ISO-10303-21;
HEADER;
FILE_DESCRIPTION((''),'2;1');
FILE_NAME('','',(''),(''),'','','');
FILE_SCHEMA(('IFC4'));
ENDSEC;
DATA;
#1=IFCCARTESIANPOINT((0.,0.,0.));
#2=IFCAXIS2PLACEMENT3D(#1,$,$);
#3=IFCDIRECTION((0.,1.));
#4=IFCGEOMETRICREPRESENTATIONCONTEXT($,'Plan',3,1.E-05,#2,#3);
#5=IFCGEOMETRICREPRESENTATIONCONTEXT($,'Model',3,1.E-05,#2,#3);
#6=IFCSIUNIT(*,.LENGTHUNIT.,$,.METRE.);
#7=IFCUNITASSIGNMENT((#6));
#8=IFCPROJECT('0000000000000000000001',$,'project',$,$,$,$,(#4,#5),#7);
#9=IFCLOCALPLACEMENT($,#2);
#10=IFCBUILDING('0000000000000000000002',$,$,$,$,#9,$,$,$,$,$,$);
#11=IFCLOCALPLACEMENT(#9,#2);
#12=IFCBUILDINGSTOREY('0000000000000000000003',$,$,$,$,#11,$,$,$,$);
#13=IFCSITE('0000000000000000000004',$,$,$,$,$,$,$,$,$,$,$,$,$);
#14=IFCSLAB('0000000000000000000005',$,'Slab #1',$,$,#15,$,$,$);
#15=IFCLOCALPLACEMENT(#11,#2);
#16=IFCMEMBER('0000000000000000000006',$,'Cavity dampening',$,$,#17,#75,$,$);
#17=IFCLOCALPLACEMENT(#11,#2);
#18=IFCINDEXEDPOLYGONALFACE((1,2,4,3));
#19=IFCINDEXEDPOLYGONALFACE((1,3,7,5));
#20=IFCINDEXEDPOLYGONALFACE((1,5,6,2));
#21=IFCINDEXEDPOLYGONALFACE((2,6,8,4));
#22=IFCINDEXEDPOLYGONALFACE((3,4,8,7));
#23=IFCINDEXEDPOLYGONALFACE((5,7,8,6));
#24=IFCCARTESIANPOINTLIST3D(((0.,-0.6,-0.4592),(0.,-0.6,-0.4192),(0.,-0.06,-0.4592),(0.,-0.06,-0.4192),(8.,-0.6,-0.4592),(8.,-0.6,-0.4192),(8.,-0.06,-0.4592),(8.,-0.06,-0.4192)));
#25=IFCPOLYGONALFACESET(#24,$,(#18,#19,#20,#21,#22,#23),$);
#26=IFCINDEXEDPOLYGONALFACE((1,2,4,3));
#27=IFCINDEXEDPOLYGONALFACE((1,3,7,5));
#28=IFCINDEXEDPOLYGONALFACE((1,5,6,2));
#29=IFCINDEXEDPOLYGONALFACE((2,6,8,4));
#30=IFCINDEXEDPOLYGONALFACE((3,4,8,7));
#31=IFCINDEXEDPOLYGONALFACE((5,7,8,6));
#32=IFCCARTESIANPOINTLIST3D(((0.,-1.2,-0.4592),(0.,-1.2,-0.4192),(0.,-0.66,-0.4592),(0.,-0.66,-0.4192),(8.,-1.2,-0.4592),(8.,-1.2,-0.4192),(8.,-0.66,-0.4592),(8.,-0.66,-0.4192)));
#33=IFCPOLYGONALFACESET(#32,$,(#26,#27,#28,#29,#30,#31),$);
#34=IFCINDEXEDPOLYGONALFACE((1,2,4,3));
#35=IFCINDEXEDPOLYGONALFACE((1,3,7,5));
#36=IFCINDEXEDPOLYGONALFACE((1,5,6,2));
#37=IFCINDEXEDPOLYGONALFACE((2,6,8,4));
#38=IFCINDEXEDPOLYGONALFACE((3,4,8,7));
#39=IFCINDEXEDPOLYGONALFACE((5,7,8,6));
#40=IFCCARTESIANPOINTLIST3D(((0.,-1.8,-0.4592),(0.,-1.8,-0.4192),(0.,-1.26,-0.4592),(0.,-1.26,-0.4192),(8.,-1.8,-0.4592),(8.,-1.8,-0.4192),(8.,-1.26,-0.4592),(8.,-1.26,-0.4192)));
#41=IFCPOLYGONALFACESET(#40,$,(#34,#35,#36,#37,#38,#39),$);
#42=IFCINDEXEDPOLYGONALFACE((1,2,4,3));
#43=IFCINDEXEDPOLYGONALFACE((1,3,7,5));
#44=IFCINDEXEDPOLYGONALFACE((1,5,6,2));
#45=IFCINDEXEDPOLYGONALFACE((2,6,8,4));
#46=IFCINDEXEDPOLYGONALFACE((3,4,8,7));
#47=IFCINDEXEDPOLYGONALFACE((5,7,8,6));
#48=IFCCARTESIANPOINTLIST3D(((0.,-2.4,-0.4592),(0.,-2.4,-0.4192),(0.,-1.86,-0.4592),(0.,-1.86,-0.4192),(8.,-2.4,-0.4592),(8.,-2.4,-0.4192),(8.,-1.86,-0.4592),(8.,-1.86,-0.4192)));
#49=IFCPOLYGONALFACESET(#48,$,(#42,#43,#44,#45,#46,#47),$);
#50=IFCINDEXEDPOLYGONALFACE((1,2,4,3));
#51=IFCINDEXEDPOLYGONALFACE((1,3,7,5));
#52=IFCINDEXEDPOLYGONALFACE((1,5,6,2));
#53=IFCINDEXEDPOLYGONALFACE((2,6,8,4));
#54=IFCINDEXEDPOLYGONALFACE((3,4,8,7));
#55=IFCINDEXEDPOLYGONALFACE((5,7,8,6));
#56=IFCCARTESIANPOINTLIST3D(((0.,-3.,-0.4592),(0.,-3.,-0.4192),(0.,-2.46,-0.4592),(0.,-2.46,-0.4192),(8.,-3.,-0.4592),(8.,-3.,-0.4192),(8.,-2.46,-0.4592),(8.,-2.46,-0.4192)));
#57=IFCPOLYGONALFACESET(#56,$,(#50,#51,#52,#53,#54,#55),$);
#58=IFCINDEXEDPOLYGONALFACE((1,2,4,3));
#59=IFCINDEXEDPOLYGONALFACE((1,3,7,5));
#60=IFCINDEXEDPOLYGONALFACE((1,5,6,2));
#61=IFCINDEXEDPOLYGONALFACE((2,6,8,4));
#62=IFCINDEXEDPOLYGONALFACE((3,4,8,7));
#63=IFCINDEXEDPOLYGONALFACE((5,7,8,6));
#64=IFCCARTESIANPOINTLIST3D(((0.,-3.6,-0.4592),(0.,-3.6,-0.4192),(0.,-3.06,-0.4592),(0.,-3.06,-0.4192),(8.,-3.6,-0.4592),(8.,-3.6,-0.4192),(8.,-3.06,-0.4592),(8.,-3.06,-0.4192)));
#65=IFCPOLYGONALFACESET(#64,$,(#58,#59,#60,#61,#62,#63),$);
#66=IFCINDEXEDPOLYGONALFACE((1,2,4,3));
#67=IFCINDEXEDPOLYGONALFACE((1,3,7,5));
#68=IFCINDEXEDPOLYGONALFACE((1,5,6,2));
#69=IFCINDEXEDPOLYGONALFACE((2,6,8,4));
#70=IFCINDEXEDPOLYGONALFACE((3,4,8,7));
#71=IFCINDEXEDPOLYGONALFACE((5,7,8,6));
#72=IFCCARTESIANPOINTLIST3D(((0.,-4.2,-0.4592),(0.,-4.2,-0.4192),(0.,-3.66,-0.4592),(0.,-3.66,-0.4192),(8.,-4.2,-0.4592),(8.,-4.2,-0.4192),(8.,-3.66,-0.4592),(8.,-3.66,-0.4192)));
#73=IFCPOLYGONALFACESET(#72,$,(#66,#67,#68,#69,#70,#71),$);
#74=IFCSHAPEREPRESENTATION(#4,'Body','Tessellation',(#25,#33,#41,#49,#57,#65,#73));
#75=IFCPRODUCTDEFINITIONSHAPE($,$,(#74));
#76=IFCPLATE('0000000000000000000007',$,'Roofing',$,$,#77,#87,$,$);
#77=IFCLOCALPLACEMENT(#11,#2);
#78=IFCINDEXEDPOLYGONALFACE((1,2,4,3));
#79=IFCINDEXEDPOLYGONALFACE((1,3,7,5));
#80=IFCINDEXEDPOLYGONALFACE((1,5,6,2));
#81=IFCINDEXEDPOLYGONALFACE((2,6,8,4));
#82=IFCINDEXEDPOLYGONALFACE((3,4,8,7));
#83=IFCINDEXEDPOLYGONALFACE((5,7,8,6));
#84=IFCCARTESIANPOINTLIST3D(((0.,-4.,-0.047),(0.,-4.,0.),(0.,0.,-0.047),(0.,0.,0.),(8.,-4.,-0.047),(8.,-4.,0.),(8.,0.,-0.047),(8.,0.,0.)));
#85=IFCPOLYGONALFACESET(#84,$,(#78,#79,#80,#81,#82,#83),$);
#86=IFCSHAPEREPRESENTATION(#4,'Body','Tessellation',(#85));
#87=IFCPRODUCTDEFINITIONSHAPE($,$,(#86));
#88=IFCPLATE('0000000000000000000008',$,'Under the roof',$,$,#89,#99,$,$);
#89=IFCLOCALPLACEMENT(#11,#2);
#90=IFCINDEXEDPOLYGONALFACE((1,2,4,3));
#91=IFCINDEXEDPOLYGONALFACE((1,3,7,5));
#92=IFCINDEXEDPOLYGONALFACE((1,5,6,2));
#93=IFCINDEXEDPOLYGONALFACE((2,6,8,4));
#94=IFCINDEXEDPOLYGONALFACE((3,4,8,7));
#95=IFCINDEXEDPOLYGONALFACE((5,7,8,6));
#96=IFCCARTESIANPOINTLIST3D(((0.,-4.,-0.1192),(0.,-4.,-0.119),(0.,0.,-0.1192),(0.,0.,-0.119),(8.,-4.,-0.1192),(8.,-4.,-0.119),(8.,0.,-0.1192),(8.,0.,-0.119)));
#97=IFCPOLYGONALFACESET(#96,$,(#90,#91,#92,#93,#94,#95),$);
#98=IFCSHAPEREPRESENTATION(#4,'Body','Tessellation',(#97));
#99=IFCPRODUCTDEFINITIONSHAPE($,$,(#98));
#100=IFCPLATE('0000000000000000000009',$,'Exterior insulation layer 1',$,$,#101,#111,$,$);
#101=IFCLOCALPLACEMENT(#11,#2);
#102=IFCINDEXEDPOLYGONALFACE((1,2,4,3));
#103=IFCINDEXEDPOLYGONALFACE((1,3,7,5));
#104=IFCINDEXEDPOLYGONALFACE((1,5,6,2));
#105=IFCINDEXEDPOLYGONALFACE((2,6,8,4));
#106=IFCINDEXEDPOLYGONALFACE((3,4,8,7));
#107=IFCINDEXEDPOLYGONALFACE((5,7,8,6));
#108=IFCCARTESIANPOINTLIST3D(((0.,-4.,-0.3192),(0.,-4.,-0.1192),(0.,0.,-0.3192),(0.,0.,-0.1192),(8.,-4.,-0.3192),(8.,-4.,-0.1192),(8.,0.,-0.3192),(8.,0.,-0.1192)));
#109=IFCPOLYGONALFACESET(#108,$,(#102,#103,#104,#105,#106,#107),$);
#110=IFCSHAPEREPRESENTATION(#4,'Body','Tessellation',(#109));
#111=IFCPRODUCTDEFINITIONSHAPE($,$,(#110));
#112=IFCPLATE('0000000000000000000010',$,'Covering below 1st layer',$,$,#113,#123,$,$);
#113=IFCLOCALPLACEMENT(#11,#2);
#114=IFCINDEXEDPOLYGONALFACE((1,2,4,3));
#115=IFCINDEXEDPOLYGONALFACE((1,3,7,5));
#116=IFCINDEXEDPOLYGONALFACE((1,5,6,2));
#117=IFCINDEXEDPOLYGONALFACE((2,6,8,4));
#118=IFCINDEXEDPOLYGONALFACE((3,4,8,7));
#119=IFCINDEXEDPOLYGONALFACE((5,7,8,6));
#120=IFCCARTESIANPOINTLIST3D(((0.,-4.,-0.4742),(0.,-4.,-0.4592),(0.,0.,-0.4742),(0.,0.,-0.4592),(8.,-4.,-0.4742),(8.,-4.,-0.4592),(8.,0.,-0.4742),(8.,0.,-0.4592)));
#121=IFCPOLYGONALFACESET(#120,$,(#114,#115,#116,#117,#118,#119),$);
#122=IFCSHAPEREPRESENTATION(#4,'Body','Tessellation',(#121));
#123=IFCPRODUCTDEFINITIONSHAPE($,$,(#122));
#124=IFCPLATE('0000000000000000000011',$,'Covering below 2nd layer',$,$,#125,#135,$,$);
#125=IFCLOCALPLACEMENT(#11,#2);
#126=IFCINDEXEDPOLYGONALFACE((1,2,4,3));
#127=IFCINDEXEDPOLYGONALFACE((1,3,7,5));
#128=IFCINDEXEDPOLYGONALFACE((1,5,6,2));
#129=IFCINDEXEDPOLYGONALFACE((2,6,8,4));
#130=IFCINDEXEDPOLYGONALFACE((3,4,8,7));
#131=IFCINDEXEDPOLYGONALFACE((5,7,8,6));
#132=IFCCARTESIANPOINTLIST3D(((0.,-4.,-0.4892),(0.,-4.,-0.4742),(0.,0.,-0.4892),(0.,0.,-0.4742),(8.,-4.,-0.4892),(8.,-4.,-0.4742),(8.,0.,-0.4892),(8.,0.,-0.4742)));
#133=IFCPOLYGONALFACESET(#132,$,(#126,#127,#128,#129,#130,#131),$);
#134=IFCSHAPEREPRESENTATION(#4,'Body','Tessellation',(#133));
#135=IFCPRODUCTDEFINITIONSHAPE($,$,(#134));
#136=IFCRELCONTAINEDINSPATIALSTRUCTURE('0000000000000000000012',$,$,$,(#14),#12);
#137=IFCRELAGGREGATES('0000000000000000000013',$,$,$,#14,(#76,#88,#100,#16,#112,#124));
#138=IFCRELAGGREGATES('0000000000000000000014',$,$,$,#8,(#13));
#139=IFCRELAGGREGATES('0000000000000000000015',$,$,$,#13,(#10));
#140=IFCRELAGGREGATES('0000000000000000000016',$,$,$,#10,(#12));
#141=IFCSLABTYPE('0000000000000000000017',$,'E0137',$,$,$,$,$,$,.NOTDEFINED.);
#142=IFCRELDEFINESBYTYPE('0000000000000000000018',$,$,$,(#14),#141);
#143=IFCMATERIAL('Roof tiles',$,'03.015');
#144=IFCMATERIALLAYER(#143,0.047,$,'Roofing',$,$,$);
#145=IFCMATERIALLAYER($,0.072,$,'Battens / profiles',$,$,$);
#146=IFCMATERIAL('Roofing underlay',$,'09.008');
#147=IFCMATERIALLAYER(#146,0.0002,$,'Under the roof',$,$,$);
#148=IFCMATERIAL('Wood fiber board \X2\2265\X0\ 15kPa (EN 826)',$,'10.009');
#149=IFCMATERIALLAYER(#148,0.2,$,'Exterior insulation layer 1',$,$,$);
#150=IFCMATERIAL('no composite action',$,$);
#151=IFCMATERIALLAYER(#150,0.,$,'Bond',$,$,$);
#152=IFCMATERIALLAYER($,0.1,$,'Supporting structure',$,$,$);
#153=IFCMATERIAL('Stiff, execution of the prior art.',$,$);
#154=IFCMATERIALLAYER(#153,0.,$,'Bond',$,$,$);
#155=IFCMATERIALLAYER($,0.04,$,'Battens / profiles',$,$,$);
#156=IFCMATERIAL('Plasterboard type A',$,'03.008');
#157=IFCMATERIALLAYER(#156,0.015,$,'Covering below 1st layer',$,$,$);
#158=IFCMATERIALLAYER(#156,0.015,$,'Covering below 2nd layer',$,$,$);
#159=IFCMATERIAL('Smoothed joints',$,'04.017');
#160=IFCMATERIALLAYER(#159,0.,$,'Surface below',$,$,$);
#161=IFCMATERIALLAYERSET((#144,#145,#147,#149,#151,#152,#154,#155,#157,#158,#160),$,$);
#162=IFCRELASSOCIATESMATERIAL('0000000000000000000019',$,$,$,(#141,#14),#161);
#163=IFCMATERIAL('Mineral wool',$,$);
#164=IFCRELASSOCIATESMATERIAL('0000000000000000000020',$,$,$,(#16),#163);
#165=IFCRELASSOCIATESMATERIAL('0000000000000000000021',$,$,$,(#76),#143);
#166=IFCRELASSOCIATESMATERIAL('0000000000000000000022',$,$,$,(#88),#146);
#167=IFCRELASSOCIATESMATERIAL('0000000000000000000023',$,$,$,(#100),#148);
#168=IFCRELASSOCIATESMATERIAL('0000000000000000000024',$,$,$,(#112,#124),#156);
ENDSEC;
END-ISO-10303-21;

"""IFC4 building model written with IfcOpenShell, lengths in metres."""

from ifc_helpers import new_model, si_unit, direction, frame, frame_2d, origin, origin_with_axes, place, context, project, spatial, rectangle, extrude, material, layer, layer_set, type_object, element, aggregate, save


model = new_model("IFC4")

# Units and contexts
plan_context = context("Plan", 3, precision=1e-05, world=origin(), true_north=direction((0.0, 1.0)))
model_context = context("Model", 3, precision=1e-05, world=origin(), true_north=direction((0.0, 1.0)))
ifc_project = project(units=[si_unit("LENGTHUNIT", "METRE")], contexts=[plan_context, model_context])

# Site, building, storey
site = spatial("IfcSite", under=ifc_project)
building_placement = place(None, origin())
building = spatial("IfcBuilding", under=site, at=building_placement)
storey_placement = place(building_placement, origin())
storey = spatial("IfcBuildingStorey", under=building, at=storey_placement)

# Slab, member, plates
ifc_material_1 = material(Name="Roof tiles", Category="03.015")
ifc_layer_1 = layer(ifc_material_1, 0.047, Name="Roofing")
ifc_layer_2 = layer(None, 0.072, Name="Battens / profiles")
ifc_material_2 = material(Name="Roofing underlay", Category="09.008")
ifc_layer_3 = layer(ifc_material_2, 0.0002, Name="Under the roof")
ifc_material_3 = material(Name="Wood fiber board ≥ 15kPa (EN 826)", Category="10.009")
ifc_layer_4 = layer(ifc_material_3, 0.2, Name="Exterior insulation layer 1")
ifc_material_4 = material(Name="no composite action")
ifc_layer_5 = layer(ifc_material_4, 0.0, Name="Bond")
ifc_layer_6 = layer(None, 0.1, Name="Supporting structure")
ifc_material_5 = material(Name="Stiff, execution of the prior art.")
ifc_layer_7 = layer(ifc_material_5, 0.0, Name="Bond")
ifc_layer_8 = layer(None, 0.04, Name="Battens / profiles")
ifc_material_6 = material(Name="Plasterboard type A", Category="03.008")
ifc_layer_9 = layer(ifc_material_6, 0.015, Name="Covering below 1st layer")
ifc_layer_10 = layer(ifc_material_6, 0.015, Name="Covering below 2nd layer")
ifc_material_7 = material(Name="Smoothed joints", Category="04.017")
ifc_layer_11 = layer(ifc_material_7, 0.0, Name="Surface below")
ifc_layer_set = layer_set([ifc_layer_1, ifc_layer_2, ifc_layer_3, ifc_layer_4, ifc_layer_5, ifc_layer_6, ifc_layer_7, ifc_layer_8, ifc_layer_9, ifc_layer_10, ifc_layer_11])
slab_type = type_object("IfcSlabType", Name="E0137", PredefinedType="NOTDEFINED", material=ifc_layer_set)
slab_placement = place(None, frame((0.0, 0.0, 0.0), z_axis=(0.0, 0.0, -1.0), x_axis=(1.0, 0.0, 0.0)))
slab = element("IfcSlab", 1, at=slab_placement, inside=storey, type_object=slab_type, material=ifc_layer_set, Name="Slab #1")
ifc_material_8 = material(Name="Mineral wool")
member_1_placement = place(slab_placement, origin())
member_1 = element("IfcMember", 2, at=member_1_placement, material=ifc_material_8, Name="Cavity dampening", context=plan_context, shape_type="SweptSolid", body=[
    extrude(rectangle(XDim=0.54, YDim=0.04, at=frame_2d((0.27, 0.02), x_axis=(1.0, 0.0))), frame((0.0, 0.06, 0.4192), z_axis=(1.0, 0.0, 0.0), x_axis=(0.0, 1.0, 0.0)), (0.0, 0.0, 1.0), 8.0),
    extrude(rectangle(XDim=0.54, YDim=0.04, at=frame_2d((0.27, 0.02), x_axis=(1.0, 0.0))), frame((0.0, 0.66, 0.4192), z_axis=(1.0, 0.0, 0.0), x_axis=(0.0, 1.0, 0.0)), (0.0, 0.0, 1.0), 8.0),
    extrude(rectangle(XDim=0.54, YDim=0.04, at=frame_2d((0.27, 0.02), x_axis=(1.0, 0.0))), frame((0.0, 1.26, 0.4192), z_axis=(1.0, 0.0, 0.0), x_axis=(0.0, 1.0, 0.0)), (0.0, 0.0, 1.0), 8.0),
    extrude(rectangle(XDim=0.54, YDim=0.04, at=frame_2d((0.27, 0.02), x_axis=(1.0, 0.0))), frame((0.0, 1.86, 0.4192), z_axis=(1.0, 0.0, 0.0), x_axis=(0.0, 1.0, 0.0)), (0.0, 0.0, 1.0), 8.0),
    extrude(rectangle(XDim=0.54, YDim=0.04, at=frame_2d((0.27, 0.02), x_axis=(1.0, 0.0))), frame((0.0, 2.46, 0.4192), z_axis=(1.0, 0.0, 0.0), x_axis=(0.0, 1.0, 0.0)), (0.0, 0.0, 1.0), 8.0),
    extrude(rectangle(XDim=0.54, YDim=0.04, at=frame_2d((0.27, 0.02), x_axis=(1.0, 0.0))), frame((0.0, 3.06, 0.4192), z_axis=(1.0, 0.0, 0.0), x_axis=(0.0, 1.0, 0.0)), (0.0, 0.0, 1.0), 8.0),
    extrude(rectangle(XDim=0.54, YDim=0.04, at=frame_2d((0.27, 0.02), x_axis=(1.0, 0.0))), frame((0.0, 3.66, 0.4192), z_axis=(1.0, 0.0, 0.0), x_axis=(0.0, 1.0, 0.0)), (0.0, 0.0, 1.0), 8.0),
])
plate_1_placement = place(slab_placement, origin())
plate_1 = element("IfcPlate", 3, at=plate_1_placement, material=ifc_material_1, Name="Roofing", context=plan_context, shape_type="SweptSolid", body=[
    extrude(rectangle(XDim=8.0, YDim=4.0, at=frame_2d((4.0, 2.0), x_axis=(1.0, 0.0))), origin_with_axes(), (0.0, 0.0, 1.0), 0.047),
])
plate_2_placement = place(slab_placement, origin())
plate_2 = element("IfcPlate", 4, at=plate_2_placement, material=ifc_material_2, Name="Under the roof", context=plan_context, shape_type="SweptSolid", body=[
    extrude(rectangle(XDim=8.0, YDim=4.0, at=frame_2d((4.0, 2.0), x_axis=(1.0, 0.0))), frame((0.0, 0.0, 0.119), z_axis=(0.0, 0.0, 1.0), x_axis=(1.0, 0.0, 0.0)), (0.0, 0.0, 1.0), 0.0002),
])
plate_3_placement = place(slab_placement, origin())
plate_3 = element("IfcPlate", 5, at=plate_3_placement, material=ifc_material_3, Name="Exterior insulation layer 1", context=plan_context, shape_type="SweptSolid", body=[
    extrude(rectangle(XDim=8.0, YDim=4.0, at=frame_2d((4.0, 2.0), x_axis=(1.0, 0.0))), frame((0.0, 0.0, 0.1192), z_axis=(0.0, 0.0, 1.0), x_axis=(1.0, 0.0, 0.0)), (0.0, 0.0, 1.0), 0.2),
])
plate_4_placement = place(slab_placement, origin())
plate_4 = element("IfcPlate", 6, at=plate_4_placement, material=ifc_material_6, Name="Covering below 1st layer", context=plan_context, shape_type="SweptSolid", body=[
    extrude(rectangle(XDim=8.0, YDim=4.0, at=frame_2d((4.0, 2.0), x_axis=(1.0, 0.0))), frame((0.0, 0.0, 0.4592), z_axis=(0.0, 0.0, 1.0), x_axis=(1.0, 0.0, 0.0)), (0.0, 0.0, 1.0), 0.015),
])
plate_5_placement = place(slab_placement, origin())
plate_5 = element("IfcPlate", 7, at=plate_5_placement, material=ifc_material_6, Name="Covering below 2nd layer", context=plan_context, shape_type="SweptSolid", body=[
    extrude(rectangle(XDim=8.0, YDim=4.0, at=frame_2d((4.0, 2.0), x_axis=(1.0, 0.0))), frame((0.0, 0.0, 0.4742), z_axis=(0.0, 0.0, 1.0), x_axis=(1.0, 0.0, 0.0)), (0.0, 0.0, 1.0), 0.015),
])
aggregate(slab, [plate_1, plate_2, plate_3, member_1, plate_4, plate_5])

save(model, "model.ifc")
